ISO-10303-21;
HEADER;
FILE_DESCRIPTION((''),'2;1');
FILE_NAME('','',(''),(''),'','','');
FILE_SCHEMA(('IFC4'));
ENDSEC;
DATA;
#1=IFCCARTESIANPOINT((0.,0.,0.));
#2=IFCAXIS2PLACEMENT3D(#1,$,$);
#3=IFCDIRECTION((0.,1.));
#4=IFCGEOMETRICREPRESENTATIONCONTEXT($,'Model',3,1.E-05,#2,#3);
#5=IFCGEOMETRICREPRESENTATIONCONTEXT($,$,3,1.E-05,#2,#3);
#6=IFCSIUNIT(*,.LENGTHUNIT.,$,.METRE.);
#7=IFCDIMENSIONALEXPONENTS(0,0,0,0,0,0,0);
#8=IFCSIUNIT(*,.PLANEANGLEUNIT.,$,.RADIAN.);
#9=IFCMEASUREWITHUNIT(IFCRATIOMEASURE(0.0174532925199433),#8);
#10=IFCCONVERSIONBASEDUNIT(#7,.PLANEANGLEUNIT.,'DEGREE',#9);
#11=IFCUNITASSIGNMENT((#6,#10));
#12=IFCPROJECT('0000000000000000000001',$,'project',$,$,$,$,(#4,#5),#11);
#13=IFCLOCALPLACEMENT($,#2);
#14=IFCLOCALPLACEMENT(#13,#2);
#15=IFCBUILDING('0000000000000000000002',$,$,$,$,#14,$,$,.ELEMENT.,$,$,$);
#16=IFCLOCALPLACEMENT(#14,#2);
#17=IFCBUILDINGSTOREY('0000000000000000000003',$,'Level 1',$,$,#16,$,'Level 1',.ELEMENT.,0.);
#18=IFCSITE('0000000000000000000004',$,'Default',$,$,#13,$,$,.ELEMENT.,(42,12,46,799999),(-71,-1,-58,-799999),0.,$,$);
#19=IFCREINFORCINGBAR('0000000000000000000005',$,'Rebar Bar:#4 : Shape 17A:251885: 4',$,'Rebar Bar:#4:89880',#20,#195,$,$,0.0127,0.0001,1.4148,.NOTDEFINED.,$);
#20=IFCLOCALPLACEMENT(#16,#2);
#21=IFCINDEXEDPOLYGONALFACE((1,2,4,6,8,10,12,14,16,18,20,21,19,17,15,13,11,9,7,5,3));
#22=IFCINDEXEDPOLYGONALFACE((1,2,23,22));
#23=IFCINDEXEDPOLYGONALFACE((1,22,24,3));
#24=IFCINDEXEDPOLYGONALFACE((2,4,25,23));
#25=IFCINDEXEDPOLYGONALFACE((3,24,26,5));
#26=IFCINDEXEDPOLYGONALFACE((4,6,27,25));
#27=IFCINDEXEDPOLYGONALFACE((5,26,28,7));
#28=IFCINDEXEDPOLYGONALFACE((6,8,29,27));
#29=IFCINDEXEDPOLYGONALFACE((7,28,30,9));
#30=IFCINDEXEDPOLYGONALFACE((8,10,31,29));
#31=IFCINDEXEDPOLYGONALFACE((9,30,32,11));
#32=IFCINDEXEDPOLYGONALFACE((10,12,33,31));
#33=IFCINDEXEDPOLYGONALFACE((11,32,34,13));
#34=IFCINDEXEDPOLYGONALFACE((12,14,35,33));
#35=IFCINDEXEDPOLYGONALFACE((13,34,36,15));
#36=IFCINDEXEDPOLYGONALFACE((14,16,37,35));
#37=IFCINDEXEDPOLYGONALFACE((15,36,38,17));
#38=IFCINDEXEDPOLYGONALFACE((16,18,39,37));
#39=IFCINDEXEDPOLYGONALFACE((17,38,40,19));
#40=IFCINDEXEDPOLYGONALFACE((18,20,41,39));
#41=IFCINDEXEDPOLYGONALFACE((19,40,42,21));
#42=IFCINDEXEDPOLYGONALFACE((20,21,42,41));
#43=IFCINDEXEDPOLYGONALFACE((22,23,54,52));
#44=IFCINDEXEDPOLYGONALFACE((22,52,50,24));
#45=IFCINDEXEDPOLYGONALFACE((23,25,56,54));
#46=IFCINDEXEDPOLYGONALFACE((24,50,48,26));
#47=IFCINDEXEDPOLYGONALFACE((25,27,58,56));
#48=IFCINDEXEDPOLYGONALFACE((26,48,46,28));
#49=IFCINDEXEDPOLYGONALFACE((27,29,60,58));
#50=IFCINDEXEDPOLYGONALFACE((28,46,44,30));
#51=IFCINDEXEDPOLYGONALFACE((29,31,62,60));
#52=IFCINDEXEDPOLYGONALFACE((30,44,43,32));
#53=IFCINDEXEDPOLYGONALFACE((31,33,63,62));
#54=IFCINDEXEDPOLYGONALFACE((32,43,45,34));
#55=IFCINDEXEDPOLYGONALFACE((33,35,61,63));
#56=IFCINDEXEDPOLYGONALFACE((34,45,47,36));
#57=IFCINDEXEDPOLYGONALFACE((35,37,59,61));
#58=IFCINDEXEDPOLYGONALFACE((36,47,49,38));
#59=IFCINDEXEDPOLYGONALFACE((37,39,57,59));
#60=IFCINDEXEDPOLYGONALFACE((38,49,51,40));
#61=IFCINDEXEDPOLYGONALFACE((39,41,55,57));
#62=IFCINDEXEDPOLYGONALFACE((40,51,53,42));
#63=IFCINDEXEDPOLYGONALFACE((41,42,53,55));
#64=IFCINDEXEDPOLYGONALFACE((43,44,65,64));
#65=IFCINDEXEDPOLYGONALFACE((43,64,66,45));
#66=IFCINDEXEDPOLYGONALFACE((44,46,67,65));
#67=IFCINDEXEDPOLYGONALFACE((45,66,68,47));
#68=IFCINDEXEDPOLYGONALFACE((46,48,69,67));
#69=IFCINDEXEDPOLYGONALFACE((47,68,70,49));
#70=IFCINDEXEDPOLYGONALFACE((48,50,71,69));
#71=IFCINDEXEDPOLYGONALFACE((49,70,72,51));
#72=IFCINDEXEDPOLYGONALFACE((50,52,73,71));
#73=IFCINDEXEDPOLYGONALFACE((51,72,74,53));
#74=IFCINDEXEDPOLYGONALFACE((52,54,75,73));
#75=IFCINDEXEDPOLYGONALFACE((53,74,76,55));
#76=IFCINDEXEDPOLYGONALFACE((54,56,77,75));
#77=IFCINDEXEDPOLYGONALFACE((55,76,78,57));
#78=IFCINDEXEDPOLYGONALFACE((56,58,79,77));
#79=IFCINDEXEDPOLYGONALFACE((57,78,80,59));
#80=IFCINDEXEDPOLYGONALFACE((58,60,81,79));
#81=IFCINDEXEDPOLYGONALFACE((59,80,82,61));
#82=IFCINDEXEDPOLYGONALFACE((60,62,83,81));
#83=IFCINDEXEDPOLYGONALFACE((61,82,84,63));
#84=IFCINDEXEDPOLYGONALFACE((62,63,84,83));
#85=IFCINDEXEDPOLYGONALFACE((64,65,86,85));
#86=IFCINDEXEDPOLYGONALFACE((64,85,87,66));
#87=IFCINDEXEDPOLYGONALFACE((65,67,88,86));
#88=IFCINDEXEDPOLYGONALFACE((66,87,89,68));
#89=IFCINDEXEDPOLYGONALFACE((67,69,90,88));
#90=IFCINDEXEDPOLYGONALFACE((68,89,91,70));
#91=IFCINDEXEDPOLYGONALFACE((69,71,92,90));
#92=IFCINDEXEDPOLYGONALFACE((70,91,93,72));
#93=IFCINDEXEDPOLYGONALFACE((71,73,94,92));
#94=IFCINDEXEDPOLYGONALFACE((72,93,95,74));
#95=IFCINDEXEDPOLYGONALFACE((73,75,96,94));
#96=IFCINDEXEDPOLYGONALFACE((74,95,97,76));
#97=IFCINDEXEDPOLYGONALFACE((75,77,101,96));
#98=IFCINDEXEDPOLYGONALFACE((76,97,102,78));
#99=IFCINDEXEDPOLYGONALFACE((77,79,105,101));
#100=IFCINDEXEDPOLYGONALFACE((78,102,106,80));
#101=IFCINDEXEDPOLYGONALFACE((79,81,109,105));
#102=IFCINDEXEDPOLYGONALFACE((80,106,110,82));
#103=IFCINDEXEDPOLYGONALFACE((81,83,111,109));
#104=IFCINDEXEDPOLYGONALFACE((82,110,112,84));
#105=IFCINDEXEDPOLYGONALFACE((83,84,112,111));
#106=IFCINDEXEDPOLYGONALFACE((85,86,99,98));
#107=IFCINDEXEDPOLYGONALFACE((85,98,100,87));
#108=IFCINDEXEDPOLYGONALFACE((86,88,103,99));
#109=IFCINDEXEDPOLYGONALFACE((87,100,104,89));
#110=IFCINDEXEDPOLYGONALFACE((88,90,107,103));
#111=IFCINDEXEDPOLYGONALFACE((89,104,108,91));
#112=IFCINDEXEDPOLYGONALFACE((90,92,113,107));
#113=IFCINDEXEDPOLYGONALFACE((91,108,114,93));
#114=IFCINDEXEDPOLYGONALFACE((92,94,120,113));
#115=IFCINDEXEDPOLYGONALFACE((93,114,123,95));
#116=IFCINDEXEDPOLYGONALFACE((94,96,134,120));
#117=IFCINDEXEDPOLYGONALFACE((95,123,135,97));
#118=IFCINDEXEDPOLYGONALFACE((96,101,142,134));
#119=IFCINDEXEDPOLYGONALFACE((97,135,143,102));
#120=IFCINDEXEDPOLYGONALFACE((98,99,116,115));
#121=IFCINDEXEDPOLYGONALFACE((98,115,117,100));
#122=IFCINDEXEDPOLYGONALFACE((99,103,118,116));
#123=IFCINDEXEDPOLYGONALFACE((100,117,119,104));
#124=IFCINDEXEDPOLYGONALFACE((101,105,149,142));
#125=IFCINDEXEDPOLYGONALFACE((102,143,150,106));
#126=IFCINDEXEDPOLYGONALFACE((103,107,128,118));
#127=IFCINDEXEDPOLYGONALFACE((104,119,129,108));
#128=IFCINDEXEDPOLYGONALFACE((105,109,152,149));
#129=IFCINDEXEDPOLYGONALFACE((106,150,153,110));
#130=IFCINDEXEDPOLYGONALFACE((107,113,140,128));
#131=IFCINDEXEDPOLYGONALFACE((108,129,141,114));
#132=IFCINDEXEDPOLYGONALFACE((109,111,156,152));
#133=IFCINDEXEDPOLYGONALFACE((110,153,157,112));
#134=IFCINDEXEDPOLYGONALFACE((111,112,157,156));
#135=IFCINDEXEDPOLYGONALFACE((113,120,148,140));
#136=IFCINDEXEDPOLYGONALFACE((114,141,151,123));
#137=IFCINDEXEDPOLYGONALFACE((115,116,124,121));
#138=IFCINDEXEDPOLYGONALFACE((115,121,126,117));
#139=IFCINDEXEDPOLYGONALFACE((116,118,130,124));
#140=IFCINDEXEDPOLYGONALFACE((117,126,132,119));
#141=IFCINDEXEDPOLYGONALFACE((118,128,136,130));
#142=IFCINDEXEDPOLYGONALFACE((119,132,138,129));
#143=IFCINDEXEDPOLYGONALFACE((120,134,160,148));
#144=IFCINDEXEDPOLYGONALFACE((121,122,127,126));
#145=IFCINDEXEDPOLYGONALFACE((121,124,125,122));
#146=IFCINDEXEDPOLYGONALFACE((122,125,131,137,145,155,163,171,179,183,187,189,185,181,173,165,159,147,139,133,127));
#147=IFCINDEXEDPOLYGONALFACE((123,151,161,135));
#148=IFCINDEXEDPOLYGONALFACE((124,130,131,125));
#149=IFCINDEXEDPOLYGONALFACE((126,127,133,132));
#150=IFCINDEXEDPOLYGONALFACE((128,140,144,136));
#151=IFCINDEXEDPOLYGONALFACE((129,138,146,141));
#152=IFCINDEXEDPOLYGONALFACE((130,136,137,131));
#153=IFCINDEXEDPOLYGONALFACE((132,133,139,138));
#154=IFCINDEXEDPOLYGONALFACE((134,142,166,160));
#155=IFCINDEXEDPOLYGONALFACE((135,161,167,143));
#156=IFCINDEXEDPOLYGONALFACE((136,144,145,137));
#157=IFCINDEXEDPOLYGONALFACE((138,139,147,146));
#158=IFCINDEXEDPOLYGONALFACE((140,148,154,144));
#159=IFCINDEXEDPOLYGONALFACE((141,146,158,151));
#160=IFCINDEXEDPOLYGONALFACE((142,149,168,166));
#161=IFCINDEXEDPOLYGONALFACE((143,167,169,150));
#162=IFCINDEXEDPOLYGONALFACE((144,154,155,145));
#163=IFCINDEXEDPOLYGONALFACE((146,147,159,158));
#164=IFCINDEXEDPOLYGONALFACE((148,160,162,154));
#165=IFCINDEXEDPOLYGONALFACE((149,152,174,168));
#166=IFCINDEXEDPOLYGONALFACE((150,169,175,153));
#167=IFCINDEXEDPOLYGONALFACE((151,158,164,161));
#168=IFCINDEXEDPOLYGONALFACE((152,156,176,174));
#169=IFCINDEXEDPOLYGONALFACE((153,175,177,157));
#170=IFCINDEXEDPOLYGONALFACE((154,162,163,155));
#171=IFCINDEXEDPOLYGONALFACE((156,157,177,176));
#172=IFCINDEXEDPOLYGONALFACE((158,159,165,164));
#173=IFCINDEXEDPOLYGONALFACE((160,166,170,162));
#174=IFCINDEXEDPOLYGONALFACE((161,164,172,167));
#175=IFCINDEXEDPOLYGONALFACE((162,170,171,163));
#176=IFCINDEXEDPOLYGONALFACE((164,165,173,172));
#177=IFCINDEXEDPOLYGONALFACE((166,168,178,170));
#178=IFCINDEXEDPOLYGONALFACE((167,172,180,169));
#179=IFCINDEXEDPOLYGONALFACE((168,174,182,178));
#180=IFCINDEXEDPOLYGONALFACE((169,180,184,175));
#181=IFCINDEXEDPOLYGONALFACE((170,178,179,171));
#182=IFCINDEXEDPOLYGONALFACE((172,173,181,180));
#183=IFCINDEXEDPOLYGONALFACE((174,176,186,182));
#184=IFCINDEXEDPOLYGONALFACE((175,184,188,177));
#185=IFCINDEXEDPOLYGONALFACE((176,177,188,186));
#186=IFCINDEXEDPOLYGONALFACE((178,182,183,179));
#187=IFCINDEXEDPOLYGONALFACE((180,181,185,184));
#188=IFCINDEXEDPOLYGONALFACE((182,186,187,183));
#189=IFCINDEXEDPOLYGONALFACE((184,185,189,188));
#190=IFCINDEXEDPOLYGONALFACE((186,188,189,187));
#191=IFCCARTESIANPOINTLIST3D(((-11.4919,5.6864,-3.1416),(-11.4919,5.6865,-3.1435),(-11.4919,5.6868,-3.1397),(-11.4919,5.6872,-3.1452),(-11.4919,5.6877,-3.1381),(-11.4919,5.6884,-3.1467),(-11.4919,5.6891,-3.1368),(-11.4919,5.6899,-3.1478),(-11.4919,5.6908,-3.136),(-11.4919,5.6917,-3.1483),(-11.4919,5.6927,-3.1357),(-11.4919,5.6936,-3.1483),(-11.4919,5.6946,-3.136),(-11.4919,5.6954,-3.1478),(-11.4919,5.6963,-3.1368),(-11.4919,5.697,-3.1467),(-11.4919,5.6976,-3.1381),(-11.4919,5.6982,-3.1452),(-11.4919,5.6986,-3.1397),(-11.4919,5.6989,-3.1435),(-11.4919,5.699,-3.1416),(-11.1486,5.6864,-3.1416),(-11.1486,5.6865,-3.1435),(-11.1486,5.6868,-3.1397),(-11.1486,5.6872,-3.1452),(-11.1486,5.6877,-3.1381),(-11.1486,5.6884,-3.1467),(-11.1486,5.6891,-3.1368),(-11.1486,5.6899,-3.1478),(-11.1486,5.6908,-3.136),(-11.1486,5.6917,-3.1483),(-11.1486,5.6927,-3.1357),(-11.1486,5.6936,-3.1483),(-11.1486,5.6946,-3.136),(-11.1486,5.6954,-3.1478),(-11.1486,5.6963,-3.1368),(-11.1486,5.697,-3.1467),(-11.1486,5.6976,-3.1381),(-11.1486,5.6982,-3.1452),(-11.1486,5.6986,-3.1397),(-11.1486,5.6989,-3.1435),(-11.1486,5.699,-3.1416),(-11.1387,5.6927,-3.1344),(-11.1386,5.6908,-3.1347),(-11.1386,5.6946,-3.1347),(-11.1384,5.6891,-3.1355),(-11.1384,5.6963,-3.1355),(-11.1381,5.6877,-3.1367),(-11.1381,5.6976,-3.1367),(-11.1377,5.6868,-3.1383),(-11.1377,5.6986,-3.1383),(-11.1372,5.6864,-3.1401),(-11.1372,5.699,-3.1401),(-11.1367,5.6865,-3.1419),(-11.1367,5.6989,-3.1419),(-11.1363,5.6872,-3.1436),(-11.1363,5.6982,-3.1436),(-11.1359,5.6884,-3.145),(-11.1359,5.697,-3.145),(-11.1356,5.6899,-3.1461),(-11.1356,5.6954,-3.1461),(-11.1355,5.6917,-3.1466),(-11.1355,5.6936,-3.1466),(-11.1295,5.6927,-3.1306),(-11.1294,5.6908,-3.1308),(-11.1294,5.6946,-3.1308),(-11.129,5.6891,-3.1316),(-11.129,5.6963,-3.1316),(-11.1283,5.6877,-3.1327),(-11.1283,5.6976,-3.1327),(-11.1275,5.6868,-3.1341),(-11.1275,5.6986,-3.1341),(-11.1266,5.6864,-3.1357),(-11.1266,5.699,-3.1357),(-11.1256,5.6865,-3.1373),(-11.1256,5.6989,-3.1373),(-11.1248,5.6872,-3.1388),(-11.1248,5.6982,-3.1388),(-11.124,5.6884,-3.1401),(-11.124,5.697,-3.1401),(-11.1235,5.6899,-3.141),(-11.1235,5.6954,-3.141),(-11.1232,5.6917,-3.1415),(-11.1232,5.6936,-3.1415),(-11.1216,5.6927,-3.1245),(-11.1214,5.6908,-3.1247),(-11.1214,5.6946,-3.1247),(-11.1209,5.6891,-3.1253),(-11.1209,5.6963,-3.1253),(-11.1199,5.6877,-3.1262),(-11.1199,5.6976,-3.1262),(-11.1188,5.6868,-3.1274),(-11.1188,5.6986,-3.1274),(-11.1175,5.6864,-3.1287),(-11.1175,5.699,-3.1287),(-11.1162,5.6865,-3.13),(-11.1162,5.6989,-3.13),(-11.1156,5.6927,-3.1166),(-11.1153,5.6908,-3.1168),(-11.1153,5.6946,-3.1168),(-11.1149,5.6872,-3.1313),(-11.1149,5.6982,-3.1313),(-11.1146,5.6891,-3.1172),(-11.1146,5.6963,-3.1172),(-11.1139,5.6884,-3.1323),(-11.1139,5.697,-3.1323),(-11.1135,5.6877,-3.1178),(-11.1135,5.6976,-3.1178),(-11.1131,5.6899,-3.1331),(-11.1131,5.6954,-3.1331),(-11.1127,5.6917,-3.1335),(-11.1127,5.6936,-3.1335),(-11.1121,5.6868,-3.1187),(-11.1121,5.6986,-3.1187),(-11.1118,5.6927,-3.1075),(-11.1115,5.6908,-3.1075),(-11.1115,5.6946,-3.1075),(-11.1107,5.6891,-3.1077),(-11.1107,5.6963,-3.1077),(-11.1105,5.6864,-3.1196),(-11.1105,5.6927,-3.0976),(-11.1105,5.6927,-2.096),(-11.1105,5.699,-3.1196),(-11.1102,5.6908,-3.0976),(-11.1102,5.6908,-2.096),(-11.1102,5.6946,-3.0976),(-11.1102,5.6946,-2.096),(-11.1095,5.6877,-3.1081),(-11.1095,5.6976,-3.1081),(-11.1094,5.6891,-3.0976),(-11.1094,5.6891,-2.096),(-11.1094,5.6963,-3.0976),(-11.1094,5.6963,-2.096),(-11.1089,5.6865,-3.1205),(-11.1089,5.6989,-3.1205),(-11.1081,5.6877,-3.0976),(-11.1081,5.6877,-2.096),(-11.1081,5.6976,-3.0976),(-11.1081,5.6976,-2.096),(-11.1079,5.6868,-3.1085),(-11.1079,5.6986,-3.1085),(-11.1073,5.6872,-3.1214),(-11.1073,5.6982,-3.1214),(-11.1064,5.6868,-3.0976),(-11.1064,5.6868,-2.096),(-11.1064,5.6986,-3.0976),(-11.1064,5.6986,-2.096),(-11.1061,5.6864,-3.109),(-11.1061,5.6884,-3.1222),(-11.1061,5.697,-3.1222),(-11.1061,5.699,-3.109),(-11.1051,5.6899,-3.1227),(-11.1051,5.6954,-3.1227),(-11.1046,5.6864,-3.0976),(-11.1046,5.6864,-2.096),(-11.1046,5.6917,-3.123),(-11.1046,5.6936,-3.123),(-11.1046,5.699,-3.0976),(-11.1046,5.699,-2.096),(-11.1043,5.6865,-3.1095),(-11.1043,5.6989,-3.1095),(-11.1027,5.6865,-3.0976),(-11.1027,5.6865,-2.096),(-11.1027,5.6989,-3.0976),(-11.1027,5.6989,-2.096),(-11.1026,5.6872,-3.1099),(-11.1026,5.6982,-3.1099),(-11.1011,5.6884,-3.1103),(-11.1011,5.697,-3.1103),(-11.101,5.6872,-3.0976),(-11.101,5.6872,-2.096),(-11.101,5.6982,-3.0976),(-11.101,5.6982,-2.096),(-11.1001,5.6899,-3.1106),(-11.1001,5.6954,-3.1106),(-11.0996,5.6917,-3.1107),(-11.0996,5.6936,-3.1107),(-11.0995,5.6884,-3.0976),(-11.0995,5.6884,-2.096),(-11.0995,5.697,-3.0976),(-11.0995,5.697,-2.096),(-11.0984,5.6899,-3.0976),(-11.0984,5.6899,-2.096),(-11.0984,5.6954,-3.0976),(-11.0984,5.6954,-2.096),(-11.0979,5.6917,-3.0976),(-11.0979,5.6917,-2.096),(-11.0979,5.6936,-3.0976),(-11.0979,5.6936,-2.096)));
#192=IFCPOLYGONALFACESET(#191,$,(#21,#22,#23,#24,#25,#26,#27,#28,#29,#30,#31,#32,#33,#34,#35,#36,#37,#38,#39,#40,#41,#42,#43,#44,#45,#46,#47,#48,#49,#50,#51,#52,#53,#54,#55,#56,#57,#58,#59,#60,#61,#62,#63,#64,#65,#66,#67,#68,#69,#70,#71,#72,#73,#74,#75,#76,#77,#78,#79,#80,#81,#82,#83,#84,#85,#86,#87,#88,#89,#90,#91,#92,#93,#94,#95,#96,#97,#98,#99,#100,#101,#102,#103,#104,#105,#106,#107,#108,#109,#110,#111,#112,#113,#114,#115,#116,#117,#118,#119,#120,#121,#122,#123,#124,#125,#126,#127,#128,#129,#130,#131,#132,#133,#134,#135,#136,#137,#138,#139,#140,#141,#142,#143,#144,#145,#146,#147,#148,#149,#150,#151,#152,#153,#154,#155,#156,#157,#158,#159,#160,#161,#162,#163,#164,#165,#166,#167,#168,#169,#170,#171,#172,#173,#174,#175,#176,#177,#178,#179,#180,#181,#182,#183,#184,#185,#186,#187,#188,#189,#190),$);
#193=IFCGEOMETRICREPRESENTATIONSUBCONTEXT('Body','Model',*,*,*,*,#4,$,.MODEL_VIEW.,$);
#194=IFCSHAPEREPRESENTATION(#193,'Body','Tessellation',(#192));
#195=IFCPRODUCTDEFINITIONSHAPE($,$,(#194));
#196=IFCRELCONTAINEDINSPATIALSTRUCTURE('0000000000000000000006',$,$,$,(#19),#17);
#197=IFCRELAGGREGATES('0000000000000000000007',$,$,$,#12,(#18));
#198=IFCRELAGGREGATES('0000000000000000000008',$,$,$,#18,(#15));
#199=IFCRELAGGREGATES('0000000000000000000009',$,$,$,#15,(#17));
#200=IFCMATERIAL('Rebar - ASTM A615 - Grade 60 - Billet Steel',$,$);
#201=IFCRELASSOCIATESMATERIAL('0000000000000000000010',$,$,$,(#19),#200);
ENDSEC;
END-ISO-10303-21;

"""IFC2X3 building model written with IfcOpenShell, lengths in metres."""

from ifc_helpers import new_model, entity, si_unit, converted_unit, direction, origin, place, context, subcontext, project, spatial, material, element, save


model = new_model("IFC2X3")

# Units and contexts
model_context = context("Model", 3, precision=1e-05, world=origin(), true_north=direction((0.0, 1.0)))
context_of_model = context(None, 3, precision=1e-05, world=origin(), true_north=direction((0.0, 1.0)))
body_context = subcontext(model_context, "Body", "Model", "MODEL_VIEW")
ifc_project = project(units=[si_unit("LENGTHUNIT", "METRE"), converted_unit("PLANEANGLEUNIT", "DEGREE", entity("IfcRatioMeasure", 0.0174532925199433), si_unit("PLANEANGLEUNIT", "RADIAN"), dimensions=[0, 0, 0, 0, 0, 0, 0])], contexts=[model_context, context_of_model])

# Site, building, storey
site_placement = place(None, origin())
site = spatial("IfcSite", under=ifc_project, at=site_placement, Name="Default", CompositionType="ELEMENT", RefLatitude=(42, 12, 46, 799999), RefLongitude=(-71, -1, -58, -799999), RefElevation=0.0)
building_placement = place(site_placement, origin())
building = spatial("IfcBuilding", under=site, at=building_placement, CompositionType="ELEMENT")
storey_placement = place(building_placement, origin())
storey = spatial("IfcBuildingStorey", under=building, at=storey_placement, Name="Level 1", LongName="Level 1", CompositionType="ELEMENT", Elevation=0.0)

# Reinforcing bar
ifc_material_1 = material(Name="Rebar - ASTM A615 - Grade 60 - Billet Steel")
reinforcing_bar_1_placement = place(storey_placement, origin())
element("IfcReinforcingBar", 1, at=reinforcing_bar_1_placement, inside=storey, material=ifc_material_1, Name="Rebar Bar:#4 : Shape 17A:251885: 4", ObjectType="Rebar Bar:#4:89880", BarLength=1.4148, BarRole="NOTDEFINED", CrossSectionArea=0.0001, NominalDiameter=0.0127, context=body_context, shape_type="AdvancedSweptSolid", body=[
    entity("IfcSweptDiskSolid", entity("IfcCompositeCurve", [entity("IfcCompositeCurveSegment", "CONTINUOUS", True, entity("IfcPolyline", [entity("IfcCartesianPoint", [-11.4919, 5.6927, -3.142]), entity("IfcCartesianPoint", [-11.1486, 5.6927, -3.142])])), entity("IfcCompositeCurveSegment", "CONTINUOUS", True, entity("IfcTrimmedCurve", entity("IfcCircle", entity("IfcAxis2Placement3D", entity("IfcCartesianPoint", [-11.1486, 5.6927, -3.0976]), entity("IfcDirection", [0.0, -1.0, 0.0]), entity("IfcDirection", [1.0, 0.0, 0.0])), 0.0445), [entity("IfcParameterValue", 270.0)], [entity("IfcParameterValue", 360.0)], True, "PARAMETER")), entity("IfcCompositeCurveSegment", "CONTINUOUS", True, entity("IfcPolyline", [entity("IfcCartesianPoint", [-11.1041, 5.6927, -3.0976]), entity("IfcCartesianPoint", [-11.1041, 5.6927, -2.096])]))], False), 0.0063, None, 0.0, 92.0),
])

save(model, "model.ifc")
